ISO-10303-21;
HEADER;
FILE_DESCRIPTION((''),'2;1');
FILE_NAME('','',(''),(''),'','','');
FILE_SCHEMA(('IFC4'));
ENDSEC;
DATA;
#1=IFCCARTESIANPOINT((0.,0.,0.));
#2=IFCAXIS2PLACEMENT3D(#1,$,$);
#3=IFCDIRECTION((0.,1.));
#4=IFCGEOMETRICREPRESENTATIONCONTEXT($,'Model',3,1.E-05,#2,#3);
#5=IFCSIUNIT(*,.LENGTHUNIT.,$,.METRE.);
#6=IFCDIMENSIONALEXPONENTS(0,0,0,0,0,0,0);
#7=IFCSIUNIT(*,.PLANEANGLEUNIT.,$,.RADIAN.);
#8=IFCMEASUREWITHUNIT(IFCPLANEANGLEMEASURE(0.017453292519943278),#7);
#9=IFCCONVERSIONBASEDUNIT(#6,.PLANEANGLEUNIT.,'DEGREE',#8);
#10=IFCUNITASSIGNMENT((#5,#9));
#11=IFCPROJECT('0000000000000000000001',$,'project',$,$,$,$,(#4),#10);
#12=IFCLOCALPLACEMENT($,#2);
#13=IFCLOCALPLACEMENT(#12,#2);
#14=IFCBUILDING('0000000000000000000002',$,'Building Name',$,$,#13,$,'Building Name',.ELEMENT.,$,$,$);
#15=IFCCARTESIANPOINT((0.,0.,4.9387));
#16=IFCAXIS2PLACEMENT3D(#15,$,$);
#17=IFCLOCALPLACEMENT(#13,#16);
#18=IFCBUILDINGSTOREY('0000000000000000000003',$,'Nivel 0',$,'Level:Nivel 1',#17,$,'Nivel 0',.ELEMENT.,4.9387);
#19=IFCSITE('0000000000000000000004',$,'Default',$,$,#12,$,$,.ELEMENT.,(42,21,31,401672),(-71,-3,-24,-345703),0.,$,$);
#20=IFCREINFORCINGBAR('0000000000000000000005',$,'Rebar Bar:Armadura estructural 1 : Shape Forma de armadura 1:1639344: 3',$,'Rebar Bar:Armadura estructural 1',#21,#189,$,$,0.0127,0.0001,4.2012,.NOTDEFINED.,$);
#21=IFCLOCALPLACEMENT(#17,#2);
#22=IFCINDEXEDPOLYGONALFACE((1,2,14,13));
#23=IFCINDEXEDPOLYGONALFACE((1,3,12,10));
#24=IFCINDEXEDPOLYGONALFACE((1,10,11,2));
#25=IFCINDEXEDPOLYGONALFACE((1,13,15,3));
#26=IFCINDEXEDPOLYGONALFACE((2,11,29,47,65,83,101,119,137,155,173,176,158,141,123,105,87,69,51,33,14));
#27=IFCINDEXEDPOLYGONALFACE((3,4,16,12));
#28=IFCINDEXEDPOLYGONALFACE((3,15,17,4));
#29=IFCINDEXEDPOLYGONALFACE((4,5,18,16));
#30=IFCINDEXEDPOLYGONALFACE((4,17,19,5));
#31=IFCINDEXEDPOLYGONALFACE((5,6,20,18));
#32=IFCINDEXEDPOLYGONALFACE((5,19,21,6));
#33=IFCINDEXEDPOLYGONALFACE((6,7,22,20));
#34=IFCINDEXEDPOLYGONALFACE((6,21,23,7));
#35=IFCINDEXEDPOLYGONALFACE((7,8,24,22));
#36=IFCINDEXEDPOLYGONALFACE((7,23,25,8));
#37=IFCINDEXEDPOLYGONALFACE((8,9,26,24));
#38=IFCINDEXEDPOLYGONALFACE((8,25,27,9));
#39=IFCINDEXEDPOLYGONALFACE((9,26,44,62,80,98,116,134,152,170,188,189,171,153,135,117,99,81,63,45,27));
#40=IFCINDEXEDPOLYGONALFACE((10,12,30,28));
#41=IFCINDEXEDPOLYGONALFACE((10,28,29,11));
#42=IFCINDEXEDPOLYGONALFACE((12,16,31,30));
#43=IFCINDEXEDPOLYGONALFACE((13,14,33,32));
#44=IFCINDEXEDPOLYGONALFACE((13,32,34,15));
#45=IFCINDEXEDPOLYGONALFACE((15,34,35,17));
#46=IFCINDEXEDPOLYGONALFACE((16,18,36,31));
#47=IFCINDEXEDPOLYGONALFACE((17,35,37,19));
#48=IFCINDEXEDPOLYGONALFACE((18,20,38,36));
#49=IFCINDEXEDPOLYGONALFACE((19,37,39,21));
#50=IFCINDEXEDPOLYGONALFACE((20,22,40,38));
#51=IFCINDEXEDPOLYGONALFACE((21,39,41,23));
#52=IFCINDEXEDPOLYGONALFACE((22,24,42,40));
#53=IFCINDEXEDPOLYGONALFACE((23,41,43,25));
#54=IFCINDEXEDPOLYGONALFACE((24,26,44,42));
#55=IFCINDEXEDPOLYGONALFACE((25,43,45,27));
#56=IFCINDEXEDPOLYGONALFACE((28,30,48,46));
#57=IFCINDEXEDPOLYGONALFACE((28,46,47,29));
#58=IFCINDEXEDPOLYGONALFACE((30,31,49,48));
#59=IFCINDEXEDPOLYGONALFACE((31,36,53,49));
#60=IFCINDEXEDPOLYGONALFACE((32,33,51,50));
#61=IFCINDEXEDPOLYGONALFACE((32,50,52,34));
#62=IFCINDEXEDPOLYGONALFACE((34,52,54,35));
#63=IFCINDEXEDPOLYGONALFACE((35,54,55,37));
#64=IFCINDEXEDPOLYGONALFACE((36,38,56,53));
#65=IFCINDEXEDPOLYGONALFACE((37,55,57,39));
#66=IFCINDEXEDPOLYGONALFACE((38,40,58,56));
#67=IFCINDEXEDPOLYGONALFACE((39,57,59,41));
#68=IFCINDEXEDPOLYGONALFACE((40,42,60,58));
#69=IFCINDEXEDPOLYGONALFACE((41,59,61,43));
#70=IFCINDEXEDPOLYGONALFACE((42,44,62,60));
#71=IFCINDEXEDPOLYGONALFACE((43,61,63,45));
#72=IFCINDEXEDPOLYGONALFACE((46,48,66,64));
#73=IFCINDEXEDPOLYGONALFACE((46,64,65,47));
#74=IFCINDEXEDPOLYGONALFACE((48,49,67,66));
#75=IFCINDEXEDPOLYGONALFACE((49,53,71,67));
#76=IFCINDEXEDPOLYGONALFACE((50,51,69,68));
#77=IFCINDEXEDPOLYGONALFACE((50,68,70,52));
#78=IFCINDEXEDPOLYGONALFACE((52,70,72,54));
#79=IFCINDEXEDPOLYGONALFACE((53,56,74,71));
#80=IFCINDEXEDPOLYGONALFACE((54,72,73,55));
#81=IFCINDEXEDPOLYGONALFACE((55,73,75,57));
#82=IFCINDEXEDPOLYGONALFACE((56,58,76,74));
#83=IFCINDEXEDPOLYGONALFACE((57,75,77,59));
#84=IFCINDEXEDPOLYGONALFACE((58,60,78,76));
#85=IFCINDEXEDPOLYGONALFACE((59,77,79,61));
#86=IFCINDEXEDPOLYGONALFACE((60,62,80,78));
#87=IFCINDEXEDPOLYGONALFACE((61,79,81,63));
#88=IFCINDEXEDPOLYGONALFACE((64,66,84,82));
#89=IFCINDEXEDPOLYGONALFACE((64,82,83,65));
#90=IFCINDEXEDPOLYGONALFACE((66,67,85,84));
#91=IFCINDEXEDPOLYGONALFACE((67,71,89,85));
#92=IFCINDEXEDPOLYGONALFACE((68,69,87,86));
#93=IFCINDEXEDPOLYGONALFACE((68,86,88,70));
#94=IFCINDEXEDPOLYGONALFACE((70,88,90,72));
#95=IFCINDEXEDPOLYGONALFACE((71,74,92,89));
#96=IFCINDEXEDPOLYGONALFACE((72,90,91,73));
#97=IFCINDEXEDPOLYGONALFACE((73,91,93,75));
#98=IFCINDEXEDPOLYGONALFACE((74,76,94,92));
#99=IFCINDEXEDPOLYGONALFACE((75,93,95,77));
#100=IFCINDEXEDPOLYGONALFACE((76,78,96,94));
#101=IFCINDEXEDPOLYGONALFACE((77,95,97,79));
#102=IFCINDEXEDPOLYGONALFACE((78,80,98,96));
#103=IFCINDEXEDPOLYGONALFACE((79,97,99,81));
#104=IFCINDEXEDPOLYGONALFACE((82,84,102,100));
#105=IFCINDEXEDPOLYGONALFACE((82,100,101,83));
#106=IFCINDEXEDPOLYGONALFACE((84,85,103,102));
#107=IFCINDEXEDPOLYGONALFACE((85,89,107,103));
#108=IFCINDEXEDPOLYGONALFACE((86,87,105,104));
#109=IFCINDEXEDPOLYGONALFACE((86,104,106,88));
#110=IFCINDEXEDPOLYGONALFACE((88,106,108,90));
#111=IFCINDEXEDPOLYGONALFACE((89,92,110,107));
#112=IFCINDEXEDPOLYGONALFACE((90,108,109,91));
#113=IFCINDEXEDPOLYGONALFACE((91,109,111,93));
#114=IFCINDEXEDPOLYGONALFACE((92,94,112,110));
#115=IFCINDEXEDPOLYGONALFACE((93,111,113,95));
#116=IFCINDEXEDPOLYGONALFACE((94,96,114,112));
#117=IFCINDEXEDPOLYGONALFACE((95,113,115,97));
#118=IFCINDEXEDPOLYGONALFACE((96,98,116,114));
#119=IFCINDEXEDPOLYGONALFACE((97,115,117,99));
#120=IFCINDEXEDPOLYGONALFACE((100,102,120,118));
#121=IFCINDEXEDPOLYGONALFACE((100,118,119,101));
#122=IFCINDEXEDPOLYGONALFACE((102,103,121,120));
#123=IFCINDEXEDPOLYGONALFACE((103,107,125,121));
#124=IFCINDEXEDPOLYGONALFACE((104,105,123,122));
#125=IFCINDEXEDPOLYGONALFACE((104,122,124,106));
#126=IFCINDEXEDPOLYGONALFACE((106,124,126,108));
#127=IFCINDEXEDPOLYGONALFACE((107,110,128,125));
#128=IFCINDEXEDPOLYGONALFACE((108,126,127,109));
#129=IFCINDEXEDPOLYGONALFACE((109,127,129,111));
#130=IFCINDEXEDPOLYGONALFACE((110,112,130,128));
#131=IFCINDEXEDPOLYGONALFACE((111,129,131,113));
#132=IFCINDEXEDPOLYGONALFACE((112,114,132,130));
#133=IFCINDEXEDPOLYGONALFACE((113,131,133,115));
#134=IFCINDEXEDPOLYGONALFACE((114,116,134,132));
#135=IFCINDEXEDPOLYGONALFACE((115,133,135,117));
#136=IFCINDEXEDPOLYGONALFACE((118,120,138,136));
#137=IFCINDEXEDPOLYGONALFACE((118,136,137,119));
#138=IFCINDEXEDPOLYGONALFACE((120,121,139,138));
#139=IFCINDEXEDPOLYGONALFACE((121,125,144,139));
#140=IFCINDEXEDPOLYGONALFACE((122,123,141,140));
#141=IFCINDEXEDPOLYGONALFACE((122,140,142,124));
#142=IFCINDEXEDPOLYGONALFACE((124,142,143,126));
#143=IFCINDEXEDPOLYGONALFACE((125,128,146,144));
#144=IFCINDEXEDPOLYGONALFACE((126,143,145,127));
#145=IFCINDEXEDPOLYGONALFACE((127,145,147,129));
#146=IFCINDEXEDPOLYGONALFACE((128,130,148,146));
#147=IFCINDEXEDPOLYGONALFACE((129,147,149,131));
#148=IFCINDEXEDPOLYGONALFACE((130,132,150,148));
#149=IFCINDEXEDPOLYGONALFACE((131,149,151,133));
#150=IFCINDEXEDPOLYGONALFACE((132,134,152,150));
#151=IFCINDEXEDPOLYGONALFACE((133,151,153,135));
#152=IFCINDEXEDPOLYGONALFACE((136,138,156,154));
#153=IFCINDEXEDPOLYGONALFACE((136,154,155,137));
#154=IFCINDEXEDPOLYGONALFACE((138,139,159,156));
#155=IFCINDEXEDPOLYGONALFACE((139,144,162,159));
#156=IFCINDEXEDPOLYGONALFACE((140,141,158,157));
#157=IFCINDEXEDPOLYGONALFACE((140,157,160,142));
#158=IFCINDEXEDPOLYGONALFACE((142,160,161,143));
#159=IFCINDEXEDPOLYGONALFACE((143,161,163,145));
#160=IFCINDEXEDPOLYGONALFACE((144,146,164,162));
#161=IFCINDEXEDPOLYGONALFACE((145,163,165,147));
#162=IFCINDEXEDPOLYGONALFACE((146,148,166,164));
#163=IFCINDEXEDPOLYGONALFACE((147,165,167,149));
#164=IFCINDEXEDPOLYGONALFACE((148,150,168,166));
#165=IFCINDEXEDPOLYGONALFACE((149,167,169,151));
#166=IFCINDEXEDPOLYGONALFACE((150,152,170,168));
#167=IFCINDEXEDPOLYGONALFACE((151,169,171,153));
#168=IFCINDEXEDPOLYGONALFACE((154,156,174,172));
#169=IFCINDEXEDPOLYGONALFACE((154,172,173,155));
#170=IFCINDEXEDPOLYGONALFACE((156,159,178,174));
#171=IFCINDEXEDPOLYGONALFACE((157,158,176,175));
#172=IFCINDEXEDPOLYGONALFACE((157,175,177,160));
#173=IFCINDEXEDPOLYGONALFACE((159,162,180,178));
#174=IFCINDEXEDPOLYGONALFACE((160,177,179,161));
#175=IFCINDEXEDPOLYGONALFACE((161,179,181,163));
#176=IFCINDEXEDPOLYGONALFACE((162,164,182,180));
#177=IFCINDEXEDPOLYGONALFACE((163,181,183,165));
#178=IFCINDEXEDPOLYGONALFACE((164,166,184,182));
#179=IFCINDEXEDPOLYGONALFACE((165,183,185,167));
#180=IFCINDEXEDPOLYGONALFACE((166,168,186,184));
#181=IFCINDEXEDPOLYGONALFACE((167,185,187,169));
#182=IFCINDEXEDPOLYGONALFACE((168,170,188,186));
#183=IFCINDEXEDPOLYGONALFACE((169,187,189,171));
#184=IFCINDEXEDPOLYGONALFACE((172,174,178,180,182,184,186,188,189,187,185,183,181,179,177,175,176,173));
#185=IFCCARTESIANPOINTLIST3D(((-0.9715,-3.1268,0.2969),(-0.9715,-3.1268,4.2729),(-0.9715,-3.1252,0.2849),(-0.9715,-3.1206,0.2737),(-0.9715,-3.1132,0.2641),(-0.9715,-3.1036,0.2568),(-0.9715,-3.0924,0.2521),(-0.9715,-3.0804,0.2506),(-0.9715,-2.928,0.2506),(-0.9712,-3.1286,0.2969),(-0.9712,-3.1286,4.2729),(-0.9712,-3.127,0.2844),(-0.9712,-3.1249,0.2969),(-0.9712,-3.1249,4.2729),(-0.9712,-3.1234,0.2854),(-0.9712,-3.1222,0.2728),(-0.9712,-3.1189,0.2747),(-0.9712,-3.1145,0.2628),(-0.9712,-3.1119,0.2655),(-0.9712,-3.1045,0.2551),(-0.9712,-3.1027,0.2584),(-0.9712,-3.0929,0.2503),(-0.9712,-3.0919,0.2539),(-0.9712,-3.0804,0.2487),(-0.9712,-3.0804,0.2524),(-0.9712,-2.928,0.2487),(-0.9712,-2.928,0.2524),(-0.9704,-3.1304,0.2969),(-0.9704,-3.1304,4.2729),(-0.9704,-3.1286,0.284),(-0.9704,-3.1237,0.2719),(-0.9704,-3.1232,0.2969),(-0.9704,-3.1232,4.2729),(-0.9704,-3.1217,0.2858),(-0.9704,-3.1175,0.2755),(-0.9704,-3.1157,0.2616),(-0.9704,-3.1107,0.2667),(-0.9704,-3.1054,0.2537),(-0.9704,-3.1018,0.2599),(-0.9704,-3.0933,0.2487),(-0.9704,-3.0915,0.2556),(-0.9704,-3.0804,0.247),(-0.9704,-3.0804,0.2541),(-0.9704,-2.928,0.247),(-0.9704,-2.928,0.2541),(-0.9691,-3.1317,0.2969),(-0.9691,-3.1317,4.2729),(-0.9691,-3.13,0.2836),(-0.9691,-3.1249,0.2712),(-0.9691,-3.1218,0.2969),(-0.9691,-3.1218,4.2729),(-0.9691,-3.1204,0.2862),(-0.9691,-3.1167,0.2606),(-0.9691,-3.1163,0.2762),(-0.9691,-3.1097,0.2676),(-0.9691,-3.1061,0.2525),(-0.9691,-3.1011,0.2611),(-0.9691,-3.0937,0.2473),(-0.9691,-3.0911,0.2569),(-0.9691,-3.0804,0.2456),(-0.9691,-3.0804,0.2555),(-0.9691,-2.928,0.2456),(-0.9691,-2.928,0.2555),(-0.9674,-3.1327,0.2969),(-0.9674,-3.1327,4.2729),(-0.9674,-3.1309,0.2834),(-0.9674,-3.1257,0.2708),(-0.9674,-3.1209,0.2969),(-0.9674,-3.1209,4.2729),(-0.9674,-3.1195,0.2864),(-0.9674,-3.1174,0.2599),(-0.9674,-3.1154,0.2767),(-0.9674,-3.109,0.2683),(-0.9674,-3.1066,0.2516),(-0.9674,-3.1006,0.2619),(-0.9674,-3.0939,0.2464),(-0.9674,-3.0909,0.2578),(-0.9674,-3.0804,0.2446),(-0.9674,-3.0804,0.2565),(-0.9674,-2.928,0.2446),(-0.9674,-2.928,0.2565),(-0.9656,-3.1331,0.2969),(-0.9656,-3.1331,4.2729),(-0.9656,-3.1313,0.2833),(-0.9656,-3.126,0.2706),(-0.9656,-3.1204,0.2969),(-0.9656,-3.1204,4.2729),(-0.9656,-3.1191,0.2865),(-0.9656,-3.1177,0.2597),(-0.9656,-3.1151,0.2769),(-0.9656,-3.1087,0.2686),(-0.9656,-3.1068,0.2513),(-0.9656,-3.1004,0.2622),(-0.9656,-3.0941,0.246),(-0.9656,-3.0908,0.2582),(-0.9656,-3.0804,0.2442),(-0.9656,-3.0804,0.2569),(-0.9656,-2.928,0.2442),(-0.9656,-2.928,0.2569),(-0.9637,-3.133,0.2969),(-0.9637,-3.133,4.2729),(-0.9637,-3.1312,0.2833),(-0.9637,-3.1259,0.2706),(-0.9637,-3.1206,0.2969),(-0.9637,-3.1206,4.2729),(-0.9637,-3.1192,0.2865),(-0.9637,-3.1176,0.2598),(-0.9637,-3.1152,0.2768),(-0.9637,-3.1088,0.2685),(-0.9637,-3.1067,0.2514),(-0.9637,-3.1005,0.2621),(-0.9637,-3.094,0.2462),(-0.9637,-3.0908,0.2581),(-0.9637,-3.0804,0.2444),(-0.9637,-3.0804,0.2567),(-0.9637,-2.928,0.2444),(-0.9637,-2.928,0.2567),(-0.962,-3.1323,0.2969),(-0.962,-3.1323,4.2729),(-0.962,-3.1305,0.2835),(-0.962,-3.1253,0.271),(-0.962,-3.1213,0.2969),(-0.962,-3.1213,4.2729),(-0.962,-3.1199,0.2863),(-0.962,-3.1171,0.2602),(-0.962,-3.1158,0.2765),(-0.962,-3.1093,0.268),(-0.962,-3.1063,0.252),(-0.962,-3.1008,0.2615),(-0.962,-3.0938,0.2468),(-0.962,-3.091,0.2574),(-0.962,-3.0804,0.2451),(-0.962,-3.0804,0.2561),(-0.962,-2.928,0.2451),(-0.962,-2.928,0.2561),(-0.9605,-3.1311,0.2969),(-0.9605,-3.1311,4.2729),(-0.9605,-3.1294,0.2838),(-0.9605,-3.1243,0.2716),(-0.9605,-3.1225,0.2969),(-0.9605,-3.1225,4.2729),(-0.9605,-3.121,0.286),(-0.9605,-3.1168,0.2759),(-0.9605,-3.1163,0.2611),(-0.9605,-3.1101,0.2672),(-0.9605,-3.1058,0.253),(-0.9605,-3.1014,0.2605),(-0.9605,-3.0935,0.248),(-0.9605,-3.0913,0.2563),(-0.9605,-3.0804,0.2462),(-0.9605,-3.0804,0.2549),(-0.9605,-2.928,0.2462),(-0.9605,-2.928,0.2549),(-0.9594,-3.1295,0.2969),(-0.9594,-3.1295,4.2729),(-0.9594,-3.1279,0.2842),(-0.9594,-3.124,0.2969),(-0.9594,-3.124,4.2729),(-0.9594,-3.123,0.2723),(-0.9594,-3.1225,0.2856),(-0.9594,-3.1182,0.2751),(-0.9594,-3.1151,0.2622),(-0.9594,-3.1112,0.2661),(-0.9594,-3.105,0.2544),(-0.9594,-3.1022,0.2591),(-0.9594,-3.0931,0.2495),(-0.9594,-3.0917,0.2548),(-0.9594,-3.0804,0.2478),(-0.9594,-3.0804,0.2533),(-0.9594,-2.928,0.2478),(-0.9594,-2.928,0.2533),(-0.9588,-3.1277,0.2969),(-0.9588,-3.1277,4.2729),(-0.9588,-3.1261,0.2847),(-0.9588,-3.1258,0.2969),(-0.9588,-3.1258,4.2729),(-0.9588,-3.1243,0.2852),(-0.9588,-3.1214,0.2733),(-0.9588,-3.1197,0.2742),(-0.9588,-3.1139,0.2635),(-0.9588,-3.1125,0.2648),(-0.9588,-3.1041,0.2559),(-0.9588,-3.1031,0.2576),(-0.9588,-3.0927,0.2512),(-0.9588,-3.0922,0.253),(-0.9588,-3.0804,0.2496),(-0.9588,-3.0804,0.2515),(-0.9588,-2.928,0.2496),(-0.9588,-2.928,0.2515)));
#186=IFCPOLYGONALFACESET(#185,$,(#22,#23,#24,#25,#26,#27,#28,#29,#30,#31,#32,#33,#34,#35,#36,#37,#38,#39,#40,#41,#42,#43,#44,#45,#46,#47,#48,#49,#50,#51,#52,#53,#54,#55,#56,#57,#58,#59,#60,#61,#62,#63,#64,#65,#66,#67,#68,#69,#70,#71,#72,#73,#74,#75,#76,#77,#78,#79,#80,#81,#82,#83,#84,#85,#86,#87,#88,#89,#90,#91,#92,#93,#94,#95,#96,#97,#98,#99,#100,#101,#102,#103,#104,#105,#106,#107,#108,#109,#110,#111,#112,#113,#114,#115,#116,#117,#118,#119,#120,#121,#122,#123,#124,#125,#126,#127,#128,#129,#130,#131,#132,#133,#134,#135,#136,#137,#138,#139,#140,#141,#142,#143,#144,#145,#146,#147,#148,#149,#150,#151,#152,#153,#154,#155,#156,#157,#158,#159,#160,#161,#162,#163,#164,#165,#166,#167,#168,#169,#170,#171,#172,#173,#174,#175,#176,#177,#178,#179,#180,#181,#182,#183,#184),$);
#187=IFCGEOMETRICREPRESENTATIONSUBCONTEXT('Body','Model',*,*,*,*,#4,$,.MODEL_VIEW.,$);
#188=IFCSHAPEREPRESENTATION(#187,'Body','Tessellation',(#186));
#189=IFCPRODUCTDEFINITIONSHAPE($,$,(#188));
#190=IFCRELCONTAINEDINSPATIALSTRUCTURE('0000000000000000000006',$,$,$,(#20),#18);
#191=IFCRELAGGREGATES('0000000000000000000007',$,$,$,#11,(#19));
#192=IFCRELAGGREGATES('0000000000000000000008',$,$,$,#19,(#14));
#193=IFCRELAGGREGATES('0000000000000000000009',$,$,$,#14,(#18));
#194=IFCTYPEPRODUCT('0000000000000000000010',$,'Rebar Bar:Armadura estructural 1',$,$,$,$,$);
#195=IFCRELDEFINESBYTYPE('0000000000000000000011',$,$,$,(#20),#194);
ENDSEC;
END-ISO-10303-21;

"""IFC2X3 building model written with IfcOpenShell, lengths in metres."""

from ifc_helpers import new_model, entity, si_unit, converted_unit, direction, frame, origin, place, context, subcontext, project, spatial, type_object, element, save


model = new_model("IFC2X3")

# Units and contexts
model_context = context("Model", 3, precision=1e-05, world=origin(), true_north=direction((0.0, 1.0)))
body_context = subcontext(model_context, "Body", "Model", "MODEL_VIEW")
ifc_project = project(units=[si_unit("LENGTHUNIT", "METRE"), converted_unit("PLANEANGLEUNIT", "DEGREE", entity("IfcPlaneAngleMeasure", 0.017453292519943278), si_unit("PLANEANGLEUNIT", "RADIAN"), dimensions=[0, 0, 0, 0, 0, 0, 0])], contexts=[model_context])

# Site, building, storey
site_placement = place(None, origin())
site = spatial("IfcSite", under=ifc_project, at=site_placement, Name="Default", CompositionType="ELEMENT", RefLatitude=(42, 21, 31, 401672), RefLongitude=(-71, -3, -24, -345703), RefElevation=0.0)
building_placement = place(site_placement, origin())
building = spatial("IfcBuilding", under=site, at=building_placement, Name="Building Name", LongName="Building Name", CompositionType="ELEMENT")
storey_placement = place(building_placement, frame((0.0, 0.0, 4.9387)))
storey = spatial("IfcBuildingStorey", under=building, at=storey_placement, Name="Nivel 0", ObjectType="Level:Nivel 1", LongName="Nivel 0", CompositionType="ELEMENT", Elevation=4.9387)

# Reinforcing bar
type_product = type_object("IfcTypeProduct", Name="Rebar Bar:Armadura estructural 1")
reinforcing_bar_1_placement = place(storey_placement, origin())
element("IfcReinforcingBar", 1, at=reinforcing_bar_1_placement, inside=storey, type_object=type_product, Name="Rebar Bar:Armadura estructural 1 : Shape Forma de armadura 1:1639344: 3", ObjectType="Rebar Bar:Armadura estructural 1", BarLength=4.2012, BarRole="NOTDEFINED", CrossSectionArea=0.0001, NominalDiameter=0.0127, context=body_context, shape_type="AdvancedSweptSolid", body=[
    entity("IfcSweptDiskSolid", entity("IfcCompositeCurve", [entity("IfcCompositeCurveSegment", "CONTINUOUS", True, entity("IfcPolyline", [entity("IfcCartesianPoint", [-0.9651, -2.928, 0.2506]), entity("IfcCartesianPoint", [-0.9651, -3.0804, 0.2506])])), entity("IfcCompositeCurveSegment", "CONTINUOUS", True, entity("IfcTrimmedCurve", entity("IfcCircle", entity("IfcAxis2Placement3D", entity("IfcCartesianPoint", [-0.9651, -3.0804, 0.2969]), entity("IfcDirection", [-1.0, 0.0, 0.0]), entity("IfcDirection", [0.0, -1.0, 0.0])), 0.0464), [entity("IfcParameterValue", 270.0)], [entity("IfcParameterValue", 360.0)], True, "PARAMETER")), entity("IfcCompositeCurveSegment", "CONTINUOUS", True, entity("IfcPolyline", [entity("IfcCartesianPoint", [-0.9651, -3.1268, 0.2969]), entity("IfcCartesianPoint", [-0.9651, -3.1268, 4.2729])]))], False), 0.0063, None, 0.0, 92.0),
])

save(model, "model.ifc")
